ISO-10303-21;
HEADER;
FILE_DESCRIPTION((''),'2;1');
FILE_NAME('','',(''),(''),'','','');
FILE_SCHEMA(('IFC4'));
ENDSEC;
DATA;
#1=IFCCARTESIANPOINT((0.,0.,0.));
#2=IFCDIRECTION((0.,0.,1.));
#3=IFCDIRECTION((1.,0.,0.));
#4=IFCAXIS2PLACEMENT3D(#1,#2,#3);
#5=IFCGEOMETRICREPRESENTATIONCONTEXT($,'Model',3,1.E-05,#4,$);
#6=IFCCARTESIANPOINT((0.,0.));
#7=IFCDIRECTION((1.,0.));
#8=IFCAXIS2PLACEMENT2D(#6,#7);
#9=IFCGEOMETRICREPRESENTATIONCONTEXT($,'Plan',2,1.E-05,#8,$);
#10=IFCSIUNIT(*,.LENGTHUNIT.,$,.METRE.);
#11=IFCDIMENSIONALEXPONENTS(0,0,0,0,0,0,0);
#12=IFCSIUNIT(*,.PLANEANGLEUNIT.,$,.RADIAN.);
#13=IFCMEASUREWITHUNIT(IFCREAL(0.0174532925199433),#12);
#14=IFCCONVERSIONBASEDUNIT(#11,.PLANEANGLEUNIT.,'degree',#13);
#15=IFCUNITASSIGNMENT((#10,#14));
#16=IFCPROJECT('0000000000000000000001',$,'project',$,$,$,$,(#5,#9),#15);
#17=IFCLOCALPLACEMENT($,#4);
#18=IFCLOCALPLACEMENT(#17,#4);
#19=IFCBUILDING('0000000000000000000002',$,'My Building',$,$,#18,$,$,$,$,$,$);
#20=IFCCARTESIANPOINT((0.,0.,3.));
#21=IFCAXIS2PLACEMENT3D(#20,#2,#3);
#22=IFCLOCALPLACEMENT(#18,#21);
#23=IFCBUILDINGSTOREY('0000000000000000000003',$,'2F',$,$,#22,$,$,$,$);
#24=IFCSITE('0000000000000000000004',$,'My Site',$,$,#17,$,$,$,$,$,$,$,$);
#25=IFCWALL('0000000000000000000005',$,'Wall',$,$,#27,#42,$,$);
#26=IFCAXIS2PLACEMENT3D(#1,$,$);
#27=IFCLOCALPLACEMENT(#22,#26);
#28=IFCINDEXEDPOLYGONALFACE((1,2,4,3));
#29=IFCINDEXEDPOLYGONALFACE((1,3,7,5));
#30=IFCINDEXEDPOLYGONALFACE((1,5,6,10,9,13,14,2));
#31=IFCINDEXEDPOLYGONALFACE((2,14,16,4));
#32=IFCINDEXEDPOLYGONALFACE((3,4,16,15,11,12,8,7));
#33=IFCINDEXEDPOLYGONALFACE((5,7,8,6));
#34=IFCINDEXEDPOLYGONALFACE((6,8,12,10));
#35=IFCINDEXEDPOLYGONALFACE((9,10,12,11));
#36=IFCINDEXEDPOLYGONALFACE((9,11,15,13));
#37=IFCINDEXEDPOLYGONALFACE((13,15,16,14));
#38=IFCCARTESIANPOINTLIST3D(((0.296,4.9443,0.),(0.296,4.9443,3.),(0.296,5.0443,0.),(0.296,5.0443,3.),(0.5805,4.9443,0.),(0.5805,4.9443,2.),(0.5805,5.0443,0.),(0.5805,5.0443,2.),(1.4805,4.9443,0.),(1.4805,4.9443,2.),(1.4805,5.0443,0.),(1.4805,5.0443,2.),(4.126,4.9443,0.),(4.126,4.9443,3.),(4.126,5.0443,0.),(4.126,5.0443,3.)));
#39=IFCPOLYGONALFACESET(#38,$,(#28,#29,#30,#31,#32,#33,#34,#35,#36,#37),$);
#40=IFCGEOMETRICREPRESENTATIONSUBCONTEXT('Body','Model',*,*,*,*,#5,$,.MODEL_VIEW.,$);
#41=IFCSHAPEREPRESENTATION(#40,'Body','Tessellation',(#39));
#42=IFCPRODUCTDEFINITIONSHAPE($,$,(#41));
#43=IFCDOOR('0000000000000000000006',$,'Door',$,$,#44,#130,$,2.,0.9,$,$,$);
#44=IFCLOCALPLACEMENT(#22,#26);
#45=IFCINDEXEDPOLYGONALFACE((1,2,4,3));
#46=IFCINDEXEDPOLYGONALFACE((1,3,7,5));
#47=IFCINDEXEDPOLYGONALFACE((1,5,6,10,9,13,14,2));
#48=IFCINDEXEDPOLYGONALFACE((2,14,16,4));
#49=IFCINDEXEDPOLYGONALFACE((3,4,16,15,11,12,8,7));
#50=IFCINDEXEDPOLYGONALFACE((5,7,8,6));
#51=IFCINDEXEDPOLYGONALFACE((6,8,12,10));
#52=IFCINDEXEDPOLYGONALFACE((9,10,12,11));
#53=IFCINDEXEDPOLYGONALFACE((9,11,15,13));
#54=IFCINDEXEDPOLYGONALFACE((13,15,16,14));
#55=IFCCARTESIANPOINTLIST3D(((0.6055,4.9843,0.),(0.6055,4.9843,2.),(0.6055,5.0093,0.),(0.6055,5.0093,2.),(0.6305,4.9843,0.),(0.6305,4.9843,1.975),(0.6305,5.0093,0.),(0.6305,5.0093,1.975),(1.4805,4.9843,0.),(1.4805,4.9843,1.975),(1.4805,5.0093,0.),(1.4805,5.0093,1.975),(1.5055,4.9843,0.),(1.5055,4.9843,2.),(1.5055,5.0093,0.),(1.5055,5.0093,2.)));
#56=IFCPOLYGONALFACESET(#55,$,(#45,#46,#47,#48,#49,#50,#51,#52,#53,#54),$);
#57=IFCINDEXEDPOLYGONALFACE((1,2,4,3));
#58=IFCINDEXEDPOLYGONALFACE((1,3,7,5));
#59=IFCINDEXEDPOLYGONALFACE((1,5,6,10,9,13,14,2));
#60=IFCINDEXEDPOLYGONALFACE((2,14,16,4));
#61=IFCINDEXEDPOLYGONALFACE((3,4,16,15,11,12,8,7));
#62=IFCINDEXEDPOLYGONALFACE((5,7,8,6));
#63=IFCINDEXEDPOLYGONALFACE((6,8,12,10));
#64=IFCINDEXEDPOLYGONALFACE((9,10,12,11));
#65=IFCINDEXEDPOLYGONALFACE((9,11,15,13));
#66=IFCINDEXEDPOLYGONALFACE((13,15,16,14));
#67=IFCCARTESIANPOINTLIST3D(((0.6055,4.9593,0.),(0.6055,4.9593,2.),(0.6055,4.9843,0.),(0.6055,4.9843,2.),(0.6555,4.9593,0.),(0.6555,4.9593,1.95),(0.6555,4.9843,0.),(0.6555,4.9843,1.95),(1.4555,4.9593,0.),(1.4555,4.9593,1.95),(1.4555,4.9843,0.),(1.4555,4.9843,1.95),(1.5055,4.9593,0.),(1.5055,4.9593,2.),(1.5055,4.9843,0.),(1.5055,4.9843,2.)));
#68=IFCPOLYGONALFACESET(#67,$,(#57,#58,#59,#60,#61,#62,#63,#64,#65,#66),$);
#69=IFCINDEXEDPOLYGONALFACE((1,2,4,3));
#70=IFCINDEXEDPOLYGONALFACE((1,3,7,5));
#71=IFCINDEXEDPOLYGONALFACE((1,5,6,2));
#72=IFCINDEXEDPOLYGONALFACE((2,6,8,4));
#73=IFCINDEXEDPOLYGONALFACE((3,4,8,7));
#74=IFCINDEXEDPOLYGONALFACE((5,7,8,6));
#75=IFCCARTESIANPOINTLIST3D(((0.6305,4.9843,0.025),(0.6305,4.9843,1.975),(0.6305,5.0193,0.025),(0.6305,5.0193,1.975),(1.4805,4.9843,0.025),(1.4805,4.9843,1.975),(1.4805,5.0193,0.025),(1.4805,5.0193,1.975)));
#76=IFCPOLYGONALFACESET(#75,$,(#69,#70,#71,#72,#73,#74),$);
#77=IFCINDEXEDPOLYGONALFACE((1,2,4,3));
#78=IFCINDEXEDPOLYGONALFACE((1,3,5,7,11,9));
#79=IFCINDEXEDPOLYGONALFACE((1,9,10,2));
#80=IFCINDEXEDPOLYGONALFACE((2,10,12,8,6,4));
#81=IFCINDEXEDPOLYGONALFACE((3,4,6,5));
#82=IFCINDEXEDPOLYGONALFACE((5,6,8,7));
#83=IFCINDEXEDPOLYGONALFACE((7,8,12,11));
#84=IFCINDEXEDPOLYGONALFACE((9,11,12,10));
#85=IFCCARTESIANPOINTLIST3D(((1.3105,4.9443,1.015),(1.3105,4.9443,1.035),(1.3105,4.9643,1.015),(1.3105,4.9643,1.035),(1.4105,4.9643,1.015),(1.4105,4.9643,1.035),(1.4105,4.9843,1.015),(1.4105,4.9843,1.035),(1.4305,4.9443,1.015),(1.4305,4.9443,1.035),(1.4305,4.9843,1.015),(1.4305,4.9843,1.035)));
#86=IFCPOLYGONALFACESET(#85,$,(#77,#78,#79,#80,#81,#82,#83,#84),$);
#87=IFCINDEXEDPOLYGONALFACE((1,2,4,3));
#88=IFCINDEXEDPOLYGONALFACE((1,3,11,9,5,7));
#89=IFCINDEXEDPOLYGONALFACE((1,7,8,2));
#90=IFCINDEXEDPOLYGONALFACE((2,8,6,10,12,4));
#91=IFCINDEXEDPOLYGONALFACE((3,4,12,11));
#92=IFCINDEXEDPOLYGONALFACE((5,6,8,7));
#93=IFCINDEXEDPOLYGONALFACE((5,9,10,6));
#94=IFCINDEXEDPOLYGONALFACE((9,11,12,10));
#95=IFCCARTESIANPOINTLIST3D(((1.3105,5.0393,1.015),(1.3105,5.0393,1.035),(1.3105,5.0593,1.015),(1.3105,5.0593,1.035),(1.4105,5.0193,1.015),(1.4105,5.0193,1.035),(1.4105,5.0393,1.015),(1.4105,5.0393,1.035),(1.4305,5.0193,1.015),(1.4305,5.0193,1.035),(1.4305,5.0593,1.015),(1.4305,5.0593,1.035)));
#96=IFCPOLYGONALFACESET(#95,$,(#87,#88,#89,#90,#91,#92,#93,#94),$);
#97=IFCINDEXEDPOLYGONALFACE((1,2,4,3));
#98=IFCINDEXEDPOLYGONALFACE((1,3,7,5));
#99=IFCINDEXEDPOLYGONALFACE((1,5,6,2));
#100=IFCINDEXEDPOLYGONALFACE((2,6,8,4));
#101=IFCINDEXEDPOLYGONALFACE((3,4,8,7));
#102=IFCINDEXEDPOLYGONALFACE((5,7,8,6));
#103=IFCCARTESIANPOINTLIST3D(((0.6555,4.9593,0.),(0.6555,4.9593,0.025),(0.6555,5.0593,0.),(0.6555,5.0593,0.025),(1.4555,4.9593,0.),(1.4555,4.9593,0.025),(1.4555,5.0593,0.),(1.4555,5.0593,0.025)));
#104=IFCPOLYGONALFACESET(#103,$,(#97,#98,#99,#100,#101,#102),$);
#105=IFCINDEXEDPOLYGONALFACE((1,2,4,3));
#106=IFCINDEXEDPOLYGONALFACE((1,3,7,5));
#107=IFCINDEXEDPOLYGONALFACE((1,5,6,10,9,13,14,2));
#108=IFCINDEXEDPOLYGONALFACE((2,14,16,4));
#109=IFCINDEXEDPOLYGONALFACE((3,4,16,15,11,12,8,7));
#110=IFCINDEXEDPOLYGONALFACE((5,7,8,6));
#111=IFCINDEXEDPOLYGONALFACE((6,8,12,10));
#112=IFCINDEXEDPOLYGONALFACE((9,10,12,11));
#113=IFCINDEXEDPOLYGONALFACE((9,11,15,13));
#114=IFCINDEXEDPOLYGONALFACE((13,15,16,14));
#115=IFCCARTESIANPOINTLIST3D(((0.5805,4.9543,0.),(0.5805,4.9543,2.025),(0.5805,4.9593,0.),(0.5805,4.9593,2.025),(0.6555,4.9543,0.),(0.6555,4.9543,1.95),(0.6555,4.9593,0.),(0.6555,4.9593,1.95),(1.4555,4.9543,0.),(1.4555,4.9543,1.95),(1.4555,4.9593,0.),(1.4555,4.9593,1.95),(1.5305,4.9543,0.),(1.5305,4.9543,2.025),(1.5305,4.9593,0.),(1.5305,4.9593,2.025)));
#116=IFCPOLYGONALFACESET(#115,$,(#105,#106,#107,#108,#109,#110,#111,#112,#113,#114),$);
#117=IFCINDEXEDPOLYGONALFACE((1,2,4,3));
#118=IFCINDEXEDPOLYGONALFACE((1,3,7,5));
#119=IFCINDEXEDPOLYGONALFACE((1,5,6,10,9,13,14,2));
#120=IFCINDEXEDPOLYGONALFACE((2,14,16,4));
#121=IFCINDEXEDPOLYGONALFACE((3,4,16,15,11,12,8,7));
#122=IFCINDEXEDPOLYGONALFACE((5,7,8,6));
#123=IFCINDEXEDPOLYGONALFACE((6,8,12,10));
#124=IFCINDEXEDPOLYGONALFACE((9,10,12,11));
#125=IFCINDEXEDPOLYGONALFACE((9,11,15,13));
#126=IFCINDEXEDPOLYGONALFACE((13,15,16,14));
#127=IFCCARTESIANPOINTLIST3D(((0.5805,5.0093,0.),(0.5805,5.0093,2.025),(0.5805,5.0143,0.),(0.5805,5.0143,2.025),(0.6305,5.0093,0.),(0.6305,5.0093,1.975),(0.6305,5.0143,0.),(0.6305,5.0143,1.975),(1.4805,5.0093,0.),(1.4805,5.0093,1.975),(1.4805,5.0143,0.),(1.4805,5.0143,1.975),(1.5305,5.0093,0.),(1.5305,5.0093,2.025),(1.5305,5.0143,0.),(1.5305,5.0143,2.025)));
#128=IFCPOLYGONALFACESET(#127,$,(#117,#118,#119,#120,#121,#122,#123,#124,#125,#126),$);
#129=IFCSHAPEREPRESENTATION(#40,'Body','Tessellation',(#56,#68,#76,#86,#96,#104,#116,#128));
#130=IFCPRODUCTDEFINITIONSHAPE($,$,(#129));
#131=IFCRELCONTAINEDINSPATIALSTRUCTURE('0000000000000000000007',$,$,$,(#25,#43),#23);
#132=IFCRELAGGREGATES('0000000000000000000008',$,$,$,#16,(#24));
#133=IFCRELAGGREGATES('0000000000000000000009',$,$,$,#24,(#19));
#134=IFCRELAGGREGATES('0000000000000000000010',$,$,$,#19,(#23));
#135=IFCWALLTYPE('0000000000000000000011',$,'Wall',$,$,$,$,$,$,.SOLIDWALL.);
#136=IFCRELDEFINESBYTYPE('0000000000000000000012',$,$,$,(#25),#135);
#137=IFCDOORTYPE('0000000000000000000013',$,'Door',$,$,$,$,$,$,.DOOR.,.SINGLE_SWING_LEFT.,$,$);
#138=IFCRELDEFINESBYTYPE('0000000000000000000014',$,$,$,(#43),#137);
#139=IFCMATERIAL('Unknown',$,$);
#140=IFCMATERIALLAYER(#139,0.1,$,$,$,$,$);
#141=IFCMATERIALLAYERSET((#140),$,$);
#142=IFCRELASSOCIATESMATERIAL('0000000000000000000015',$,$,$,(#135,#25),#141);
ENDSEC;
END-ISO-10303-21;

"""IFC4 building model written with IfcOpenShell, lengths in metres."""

from ifc_helpers import new_model, entity, si_unit, converted_unit, frame, origin_with_axes, origin_2d_with_axis, place, context, subcontext, project, spatial, line, indexed_curve, outline, extrude, shape, source, transform, mapped, material, layer, layer_set, layer_usage, type_object, type_shapes, element, fill, save


model = new_model("IFC4")

# Units and contexts
model_context = context("Model", 3, precision=1e-05, world=origin_with_axes())
plan_context = context("Plan", 2, precision=1e-05, world=origin_2d_with_axis())
body_context_1 = subcontext(model_context, "Body", "Model", "MODEL_VIEW")
body_context_2 = subcontext(plan_context, "Body", "Plan", "PLAN_VIEW")
ifc_project = project(units=[si_unit("LENGTHUNIT", "METRE"), converted_unit("PLANEANGLEUNIT", "degree", entity("IfcReal", 0.0174532925199433), si_unit("PLANEANGLEUNIT", "RADIAN"), dimensions=[0, 0, 0, 0, 0, 0, 0])], contexts=[model_context, plan_context])

# Site, building, storey
site_placement = place(None, origin_with_axes())
site = spatial("IfcSite", under=ifc_project, at=site_placement, Name="My Site")
building_placement = place(site_placement, origin_with_axes())
building = spatial("IfcBuilding", under=site, at=building_placement, Name="My Building")
storey_placement = place(building_placement, frame((0.0, 0.0, 3.0), z_axis=(0.0, 0.0, 1.0), x_axis=(1.0, 0.0, 0.0)))
storey = spatial("IfcBuildingStorey", under=building, at=storey_placement, Name="2F")

# Shared definitions
ifc_material = material(Name="Unknown")
ifc_layer = layer(ifc_material, 0.1)
ifc_layer_set = layer_set([ifc_layer])
wall_type = type_object("IfcWallType", Name="Wall", PredefinedType="SOLIDWALL", material=ifc_layer_set)

# Wall, opening, door
shared_shape_1 = source(origin_with_axes(), body_context_1, "Body", "SweptSolid", [
    extrude(outline(indexed_curve([(0.0, 0.0), (0.9, 0.0), (0.9, 2.0), (0.0, 2.0)], segments=[line(1, 2, 3, 4, 1)])), frame((0.0, -0.6, 0.0), z_axis=(0.0, -1.0, 0.0), x_axis=(1.0, 0.0, 0.0)), (0.0, 0.0, -1.0), 1.2),
])
door_type_1 = type_object("IfcDoorType", Name="Door", OperationType="SINGLE_SWING_LEFT", PredefinedType="DOOR")
shared_shape_2 = source(origin_with_axes(), body_context_1, "Body", "SweptSolid", [
    extrude(outline(indexed_curve([(0.0, 0.0), (0.0, 2.0), (0.9, 2.0), (0.9, 0.0), (0.875, 0.0), (0.875, 1.975), (0.025, 1.975), (0.025, 0.0)], segments=[line(1, 2, 3, 4, 5, 6, 7, 8, 1)])), frame((0.0, 0.025, 0.0), z_axis=(0.0, -1.0, 0.0), x_axis=(1.0, 0.0, 0.0)), (0.0, 0.0, -1.0), 0.025),
    extrude(outline(indexed_curve([(0.0, 0.0), (0.0, 2.0), (0.9, 2.0), (0.9, 0.0), (0.85, 0.0), (0.85, 1.95), (0.05, 1.95), (0.05, 0.0)], segments=[line(1, 2, 3, 4, 5, 6, 7, 8, 1)])), frame((0.0, 0.0, 0.0), z_axis=(0.0, -1.0, 0.0), x_axis=(1.0, 0.0, 0.0)), (0.0, 0.0, -1.0), 0.025),
    extrude(outline(indexed_curve([(0.0, 0.0), (0.85, 0.0), (0.85, 0.035), (0.0, 0.035)], segments=[line(1, 2, 3, 4, 1)])), frame((0.025, 0.025, 0.025), z_axis=(0.0, 0.0, 1.0), x_axis=(1.0, 0.0, 0.0)), (0.0, 0.0, 1.0), 1.95),
    extrude(outline(indexed_curve([(0.0, 0.0), (0.0, -0.04), (-0.12, -0.04), (-0.12, -0.02), (-0.02, -0.02), (-0.02, 0.0)], segments=[line(1, 2, 3, 4, 5, 6, 1)])), frame((0.825, 0.025, 1.015), z_axis=(0.0, 0.0, 1.0), x_axis=(1.0, 0.0, 0.0)), (0.0, 0.0, 1.0), 0.02),
    extrude(outline(indexed_curve([(0.0, 0.0), (0.0, 0.04), (-0.12, 0.04), (-0.12, 0.02), (-0.02, 0.02), (-0.02, 0.0)], segments=[line(1, 2, 3, 4, 5, 6, 1)])), frame((0.825, 0.06, 1.015), z_axis=(0.0, 0.0, 1.0), x_axis=(1.0, 0.0, 0.0)), (0.0, 0.0, 1.0), 0.02),
    extrude(outline(indexed_curve([(0.0, 0.0), (0.8, 0.0), (0.8, 0.1), (0.0, 0.1)], segments=[line(1, 2, 3, 4, 1)])), frame((0.05, 0.0, 0.0), z_axis=(0.0, 0.0, 1.0), x_axis=(1.0, 0.0, 0.0)), (0.0, 0.0, 1.0), 0.025),
    extrude(outline(indexed_curve([(0.0, 0.0), (0.0, 2.025), (0.95, 2.025), (0.95, 0.0), (0.875, 0.0), (0.875, 1.95), (0.075, 1.95), (0.075, 0.0)], segments=[line(1, 2, 3, 4, 5, 6, 7, 8, 1)])), frame((-0.025, -0.005, 0.0), z_axis=(0.0, -1.0, 0.0), x_axis=(1.0, 0.0, 0.0)), (0.0, 0.0, -1.0), 0.005),
    extrude(outline(indexed_curve([(0.0, 0.0), (0.0, 2.025), (0.95, 2.025), (0.95, 0.0), (0.9, 0.0), (0.9, 1.975), (0.05, 1.975), (0.05, 0.0)], segments=[line(1, 2, 3, 4, 5, 6, 7, 8, 1)])), frame((-0.025, 0.05, 0.0), z_axis=(0.0, -1.0, 0.0), x_axis=(1.0, 0.0, 0.0)), (0.0, 0.0, -1.0), 0.005),
])
shared_shape_3 = source(origin_with_axes(), body_context_2, "Body", "Curve2D", [
    entity("IfcIndexedPolyCurve", entity("IfcCartesianPointList2D", [[0.0, 0.0], [0.0, 0.05], [0.025, 0.05], [0.025, 0.025], [0.05, 0.025], [0.05, 0.0]]), [entity("IfcLineIndex", [1, 2, 3, 4, 5, 6, 1])]),
    entity("IfcIndexedPolyCurve", entity("IfcCartesianPointList2D", [[0.9, 0.0], [0.9, 0.05], [0.875, 0.05], [0.875, 0.025], [0.85, 0.025], [0.85, 0.0]]), [entity("IfcLineIndex", [1, 2, 3, 4, 5, 6, 1])]),
    entity("IfcTrimmedCurve", entity("IfcEllipse", entity("IfcAxis2Placement2D", entity("IfcCartesianPoint", [0.06, 0.05]), entity("IfcDirection", [1.0, 0.0])), 0.815, 0.85), [entity("IfcCartesianPoint", [0.875, 0.05])], [entity("IfcCartesianPoint", [0.06, 0.9])], True, "CARTESIAN"),
    entity("IfcIndexedPolyCurve", entity("IfcCartesianPointList2D", [[0.025, 0.05], [0.06, 0.05], [0.06, 0.9], [0.025, 0.9]]), [entity("IfcLineIndex", [1, 2, 3, 4, 1])]),
])
type_shapes(door_type_1, [shared_shape_2, shared_shape_3])
ifc_layer_usage_1 = layer_usage(ifc_layer_set, "AXIS2", "POSITIVE", 0.0)
wall_1_placement = place(storey_placement, frame((4.126, 5.0443, 0.0), z_axis=(0.0, 0.0, 1.0), x_axis=(-1.0, -0.000001, 0.0)))
wall_1 = element("IfcWall", 1, at=wall_1_placement, inside=storey, type_object=wall_type, material=ifc_layer_usage_1, Name="Wall", context=body_context_1, shape_type="SweptSolid", body=[
    extrude(outline(indexed_curve([(0.0, 0.0), (0.0, 0.1), (3.83, 0.1), (3.83, 0.0)], segments=[line(1, 2, 3, 4, 1)])), origin_with_axes(), (0.0, 0.0, 1.0), 3.0),
])
opening_1_placement = place(wall_1_placement, frame((2.6455, 0.0, 0.0), z_axis=(0.0, 0.0, 1.0), x_axis=(1.0, 0.0, 0.0)))
opening_1 = element("IfcOpeningElement", 2, at=opening_1_placement, cuts=wall_1, PredefinedType="OPENING", context=body_context_1, shape_type="MappedRepresentation", body=[
    mapped(shared_shape_1, transform((0.0, 0.0, 0.0), x_axis=(1.0, 0.0, 0.0), y_axis=(0.0, 1.0, 0.0), z_axis=(0.0, 0.0, 1.0), scale=1.0)),
])
door_1_placement = place(opening_1_placement, frame((0.875, 0.085, 0.0), z_axis=(0.0, 0.0, 1.0), x_axis=(-1.0, 0.0, 0.0)))
door_1 = element("IfcDoor", 3, at=door_1_placement, inside=storey, type_object=door_type_1, Name="Door", OverallHeight=2.0, OverallWidth=0.9, shapes=[
    shape(body_context_1, "Body", "MappedRepresentation", [mapped(shared_shape_2, transform((0.0, 0.0, 0.0), x_axis=(1.0, 0.0, 0.0), y_axis=(0.0, 1.0, 0.0), z_axis=(0.0, 0.0, 1.0), scale=1.0))]),
    shape(body_context_2, "Body", "MappedRepresentation", [mapped(shared_shape_3, transform((0.0, 0.0, 0.0), x_axis=(1.0, 0.0, 0.0), y_axis=(0.0, 1.0, 0.0), z_axis=(0.0, 0.0, 1.0), scale=1.0))]),
])
fill(opening_1, door_1)

save(model, "model.ifc")
